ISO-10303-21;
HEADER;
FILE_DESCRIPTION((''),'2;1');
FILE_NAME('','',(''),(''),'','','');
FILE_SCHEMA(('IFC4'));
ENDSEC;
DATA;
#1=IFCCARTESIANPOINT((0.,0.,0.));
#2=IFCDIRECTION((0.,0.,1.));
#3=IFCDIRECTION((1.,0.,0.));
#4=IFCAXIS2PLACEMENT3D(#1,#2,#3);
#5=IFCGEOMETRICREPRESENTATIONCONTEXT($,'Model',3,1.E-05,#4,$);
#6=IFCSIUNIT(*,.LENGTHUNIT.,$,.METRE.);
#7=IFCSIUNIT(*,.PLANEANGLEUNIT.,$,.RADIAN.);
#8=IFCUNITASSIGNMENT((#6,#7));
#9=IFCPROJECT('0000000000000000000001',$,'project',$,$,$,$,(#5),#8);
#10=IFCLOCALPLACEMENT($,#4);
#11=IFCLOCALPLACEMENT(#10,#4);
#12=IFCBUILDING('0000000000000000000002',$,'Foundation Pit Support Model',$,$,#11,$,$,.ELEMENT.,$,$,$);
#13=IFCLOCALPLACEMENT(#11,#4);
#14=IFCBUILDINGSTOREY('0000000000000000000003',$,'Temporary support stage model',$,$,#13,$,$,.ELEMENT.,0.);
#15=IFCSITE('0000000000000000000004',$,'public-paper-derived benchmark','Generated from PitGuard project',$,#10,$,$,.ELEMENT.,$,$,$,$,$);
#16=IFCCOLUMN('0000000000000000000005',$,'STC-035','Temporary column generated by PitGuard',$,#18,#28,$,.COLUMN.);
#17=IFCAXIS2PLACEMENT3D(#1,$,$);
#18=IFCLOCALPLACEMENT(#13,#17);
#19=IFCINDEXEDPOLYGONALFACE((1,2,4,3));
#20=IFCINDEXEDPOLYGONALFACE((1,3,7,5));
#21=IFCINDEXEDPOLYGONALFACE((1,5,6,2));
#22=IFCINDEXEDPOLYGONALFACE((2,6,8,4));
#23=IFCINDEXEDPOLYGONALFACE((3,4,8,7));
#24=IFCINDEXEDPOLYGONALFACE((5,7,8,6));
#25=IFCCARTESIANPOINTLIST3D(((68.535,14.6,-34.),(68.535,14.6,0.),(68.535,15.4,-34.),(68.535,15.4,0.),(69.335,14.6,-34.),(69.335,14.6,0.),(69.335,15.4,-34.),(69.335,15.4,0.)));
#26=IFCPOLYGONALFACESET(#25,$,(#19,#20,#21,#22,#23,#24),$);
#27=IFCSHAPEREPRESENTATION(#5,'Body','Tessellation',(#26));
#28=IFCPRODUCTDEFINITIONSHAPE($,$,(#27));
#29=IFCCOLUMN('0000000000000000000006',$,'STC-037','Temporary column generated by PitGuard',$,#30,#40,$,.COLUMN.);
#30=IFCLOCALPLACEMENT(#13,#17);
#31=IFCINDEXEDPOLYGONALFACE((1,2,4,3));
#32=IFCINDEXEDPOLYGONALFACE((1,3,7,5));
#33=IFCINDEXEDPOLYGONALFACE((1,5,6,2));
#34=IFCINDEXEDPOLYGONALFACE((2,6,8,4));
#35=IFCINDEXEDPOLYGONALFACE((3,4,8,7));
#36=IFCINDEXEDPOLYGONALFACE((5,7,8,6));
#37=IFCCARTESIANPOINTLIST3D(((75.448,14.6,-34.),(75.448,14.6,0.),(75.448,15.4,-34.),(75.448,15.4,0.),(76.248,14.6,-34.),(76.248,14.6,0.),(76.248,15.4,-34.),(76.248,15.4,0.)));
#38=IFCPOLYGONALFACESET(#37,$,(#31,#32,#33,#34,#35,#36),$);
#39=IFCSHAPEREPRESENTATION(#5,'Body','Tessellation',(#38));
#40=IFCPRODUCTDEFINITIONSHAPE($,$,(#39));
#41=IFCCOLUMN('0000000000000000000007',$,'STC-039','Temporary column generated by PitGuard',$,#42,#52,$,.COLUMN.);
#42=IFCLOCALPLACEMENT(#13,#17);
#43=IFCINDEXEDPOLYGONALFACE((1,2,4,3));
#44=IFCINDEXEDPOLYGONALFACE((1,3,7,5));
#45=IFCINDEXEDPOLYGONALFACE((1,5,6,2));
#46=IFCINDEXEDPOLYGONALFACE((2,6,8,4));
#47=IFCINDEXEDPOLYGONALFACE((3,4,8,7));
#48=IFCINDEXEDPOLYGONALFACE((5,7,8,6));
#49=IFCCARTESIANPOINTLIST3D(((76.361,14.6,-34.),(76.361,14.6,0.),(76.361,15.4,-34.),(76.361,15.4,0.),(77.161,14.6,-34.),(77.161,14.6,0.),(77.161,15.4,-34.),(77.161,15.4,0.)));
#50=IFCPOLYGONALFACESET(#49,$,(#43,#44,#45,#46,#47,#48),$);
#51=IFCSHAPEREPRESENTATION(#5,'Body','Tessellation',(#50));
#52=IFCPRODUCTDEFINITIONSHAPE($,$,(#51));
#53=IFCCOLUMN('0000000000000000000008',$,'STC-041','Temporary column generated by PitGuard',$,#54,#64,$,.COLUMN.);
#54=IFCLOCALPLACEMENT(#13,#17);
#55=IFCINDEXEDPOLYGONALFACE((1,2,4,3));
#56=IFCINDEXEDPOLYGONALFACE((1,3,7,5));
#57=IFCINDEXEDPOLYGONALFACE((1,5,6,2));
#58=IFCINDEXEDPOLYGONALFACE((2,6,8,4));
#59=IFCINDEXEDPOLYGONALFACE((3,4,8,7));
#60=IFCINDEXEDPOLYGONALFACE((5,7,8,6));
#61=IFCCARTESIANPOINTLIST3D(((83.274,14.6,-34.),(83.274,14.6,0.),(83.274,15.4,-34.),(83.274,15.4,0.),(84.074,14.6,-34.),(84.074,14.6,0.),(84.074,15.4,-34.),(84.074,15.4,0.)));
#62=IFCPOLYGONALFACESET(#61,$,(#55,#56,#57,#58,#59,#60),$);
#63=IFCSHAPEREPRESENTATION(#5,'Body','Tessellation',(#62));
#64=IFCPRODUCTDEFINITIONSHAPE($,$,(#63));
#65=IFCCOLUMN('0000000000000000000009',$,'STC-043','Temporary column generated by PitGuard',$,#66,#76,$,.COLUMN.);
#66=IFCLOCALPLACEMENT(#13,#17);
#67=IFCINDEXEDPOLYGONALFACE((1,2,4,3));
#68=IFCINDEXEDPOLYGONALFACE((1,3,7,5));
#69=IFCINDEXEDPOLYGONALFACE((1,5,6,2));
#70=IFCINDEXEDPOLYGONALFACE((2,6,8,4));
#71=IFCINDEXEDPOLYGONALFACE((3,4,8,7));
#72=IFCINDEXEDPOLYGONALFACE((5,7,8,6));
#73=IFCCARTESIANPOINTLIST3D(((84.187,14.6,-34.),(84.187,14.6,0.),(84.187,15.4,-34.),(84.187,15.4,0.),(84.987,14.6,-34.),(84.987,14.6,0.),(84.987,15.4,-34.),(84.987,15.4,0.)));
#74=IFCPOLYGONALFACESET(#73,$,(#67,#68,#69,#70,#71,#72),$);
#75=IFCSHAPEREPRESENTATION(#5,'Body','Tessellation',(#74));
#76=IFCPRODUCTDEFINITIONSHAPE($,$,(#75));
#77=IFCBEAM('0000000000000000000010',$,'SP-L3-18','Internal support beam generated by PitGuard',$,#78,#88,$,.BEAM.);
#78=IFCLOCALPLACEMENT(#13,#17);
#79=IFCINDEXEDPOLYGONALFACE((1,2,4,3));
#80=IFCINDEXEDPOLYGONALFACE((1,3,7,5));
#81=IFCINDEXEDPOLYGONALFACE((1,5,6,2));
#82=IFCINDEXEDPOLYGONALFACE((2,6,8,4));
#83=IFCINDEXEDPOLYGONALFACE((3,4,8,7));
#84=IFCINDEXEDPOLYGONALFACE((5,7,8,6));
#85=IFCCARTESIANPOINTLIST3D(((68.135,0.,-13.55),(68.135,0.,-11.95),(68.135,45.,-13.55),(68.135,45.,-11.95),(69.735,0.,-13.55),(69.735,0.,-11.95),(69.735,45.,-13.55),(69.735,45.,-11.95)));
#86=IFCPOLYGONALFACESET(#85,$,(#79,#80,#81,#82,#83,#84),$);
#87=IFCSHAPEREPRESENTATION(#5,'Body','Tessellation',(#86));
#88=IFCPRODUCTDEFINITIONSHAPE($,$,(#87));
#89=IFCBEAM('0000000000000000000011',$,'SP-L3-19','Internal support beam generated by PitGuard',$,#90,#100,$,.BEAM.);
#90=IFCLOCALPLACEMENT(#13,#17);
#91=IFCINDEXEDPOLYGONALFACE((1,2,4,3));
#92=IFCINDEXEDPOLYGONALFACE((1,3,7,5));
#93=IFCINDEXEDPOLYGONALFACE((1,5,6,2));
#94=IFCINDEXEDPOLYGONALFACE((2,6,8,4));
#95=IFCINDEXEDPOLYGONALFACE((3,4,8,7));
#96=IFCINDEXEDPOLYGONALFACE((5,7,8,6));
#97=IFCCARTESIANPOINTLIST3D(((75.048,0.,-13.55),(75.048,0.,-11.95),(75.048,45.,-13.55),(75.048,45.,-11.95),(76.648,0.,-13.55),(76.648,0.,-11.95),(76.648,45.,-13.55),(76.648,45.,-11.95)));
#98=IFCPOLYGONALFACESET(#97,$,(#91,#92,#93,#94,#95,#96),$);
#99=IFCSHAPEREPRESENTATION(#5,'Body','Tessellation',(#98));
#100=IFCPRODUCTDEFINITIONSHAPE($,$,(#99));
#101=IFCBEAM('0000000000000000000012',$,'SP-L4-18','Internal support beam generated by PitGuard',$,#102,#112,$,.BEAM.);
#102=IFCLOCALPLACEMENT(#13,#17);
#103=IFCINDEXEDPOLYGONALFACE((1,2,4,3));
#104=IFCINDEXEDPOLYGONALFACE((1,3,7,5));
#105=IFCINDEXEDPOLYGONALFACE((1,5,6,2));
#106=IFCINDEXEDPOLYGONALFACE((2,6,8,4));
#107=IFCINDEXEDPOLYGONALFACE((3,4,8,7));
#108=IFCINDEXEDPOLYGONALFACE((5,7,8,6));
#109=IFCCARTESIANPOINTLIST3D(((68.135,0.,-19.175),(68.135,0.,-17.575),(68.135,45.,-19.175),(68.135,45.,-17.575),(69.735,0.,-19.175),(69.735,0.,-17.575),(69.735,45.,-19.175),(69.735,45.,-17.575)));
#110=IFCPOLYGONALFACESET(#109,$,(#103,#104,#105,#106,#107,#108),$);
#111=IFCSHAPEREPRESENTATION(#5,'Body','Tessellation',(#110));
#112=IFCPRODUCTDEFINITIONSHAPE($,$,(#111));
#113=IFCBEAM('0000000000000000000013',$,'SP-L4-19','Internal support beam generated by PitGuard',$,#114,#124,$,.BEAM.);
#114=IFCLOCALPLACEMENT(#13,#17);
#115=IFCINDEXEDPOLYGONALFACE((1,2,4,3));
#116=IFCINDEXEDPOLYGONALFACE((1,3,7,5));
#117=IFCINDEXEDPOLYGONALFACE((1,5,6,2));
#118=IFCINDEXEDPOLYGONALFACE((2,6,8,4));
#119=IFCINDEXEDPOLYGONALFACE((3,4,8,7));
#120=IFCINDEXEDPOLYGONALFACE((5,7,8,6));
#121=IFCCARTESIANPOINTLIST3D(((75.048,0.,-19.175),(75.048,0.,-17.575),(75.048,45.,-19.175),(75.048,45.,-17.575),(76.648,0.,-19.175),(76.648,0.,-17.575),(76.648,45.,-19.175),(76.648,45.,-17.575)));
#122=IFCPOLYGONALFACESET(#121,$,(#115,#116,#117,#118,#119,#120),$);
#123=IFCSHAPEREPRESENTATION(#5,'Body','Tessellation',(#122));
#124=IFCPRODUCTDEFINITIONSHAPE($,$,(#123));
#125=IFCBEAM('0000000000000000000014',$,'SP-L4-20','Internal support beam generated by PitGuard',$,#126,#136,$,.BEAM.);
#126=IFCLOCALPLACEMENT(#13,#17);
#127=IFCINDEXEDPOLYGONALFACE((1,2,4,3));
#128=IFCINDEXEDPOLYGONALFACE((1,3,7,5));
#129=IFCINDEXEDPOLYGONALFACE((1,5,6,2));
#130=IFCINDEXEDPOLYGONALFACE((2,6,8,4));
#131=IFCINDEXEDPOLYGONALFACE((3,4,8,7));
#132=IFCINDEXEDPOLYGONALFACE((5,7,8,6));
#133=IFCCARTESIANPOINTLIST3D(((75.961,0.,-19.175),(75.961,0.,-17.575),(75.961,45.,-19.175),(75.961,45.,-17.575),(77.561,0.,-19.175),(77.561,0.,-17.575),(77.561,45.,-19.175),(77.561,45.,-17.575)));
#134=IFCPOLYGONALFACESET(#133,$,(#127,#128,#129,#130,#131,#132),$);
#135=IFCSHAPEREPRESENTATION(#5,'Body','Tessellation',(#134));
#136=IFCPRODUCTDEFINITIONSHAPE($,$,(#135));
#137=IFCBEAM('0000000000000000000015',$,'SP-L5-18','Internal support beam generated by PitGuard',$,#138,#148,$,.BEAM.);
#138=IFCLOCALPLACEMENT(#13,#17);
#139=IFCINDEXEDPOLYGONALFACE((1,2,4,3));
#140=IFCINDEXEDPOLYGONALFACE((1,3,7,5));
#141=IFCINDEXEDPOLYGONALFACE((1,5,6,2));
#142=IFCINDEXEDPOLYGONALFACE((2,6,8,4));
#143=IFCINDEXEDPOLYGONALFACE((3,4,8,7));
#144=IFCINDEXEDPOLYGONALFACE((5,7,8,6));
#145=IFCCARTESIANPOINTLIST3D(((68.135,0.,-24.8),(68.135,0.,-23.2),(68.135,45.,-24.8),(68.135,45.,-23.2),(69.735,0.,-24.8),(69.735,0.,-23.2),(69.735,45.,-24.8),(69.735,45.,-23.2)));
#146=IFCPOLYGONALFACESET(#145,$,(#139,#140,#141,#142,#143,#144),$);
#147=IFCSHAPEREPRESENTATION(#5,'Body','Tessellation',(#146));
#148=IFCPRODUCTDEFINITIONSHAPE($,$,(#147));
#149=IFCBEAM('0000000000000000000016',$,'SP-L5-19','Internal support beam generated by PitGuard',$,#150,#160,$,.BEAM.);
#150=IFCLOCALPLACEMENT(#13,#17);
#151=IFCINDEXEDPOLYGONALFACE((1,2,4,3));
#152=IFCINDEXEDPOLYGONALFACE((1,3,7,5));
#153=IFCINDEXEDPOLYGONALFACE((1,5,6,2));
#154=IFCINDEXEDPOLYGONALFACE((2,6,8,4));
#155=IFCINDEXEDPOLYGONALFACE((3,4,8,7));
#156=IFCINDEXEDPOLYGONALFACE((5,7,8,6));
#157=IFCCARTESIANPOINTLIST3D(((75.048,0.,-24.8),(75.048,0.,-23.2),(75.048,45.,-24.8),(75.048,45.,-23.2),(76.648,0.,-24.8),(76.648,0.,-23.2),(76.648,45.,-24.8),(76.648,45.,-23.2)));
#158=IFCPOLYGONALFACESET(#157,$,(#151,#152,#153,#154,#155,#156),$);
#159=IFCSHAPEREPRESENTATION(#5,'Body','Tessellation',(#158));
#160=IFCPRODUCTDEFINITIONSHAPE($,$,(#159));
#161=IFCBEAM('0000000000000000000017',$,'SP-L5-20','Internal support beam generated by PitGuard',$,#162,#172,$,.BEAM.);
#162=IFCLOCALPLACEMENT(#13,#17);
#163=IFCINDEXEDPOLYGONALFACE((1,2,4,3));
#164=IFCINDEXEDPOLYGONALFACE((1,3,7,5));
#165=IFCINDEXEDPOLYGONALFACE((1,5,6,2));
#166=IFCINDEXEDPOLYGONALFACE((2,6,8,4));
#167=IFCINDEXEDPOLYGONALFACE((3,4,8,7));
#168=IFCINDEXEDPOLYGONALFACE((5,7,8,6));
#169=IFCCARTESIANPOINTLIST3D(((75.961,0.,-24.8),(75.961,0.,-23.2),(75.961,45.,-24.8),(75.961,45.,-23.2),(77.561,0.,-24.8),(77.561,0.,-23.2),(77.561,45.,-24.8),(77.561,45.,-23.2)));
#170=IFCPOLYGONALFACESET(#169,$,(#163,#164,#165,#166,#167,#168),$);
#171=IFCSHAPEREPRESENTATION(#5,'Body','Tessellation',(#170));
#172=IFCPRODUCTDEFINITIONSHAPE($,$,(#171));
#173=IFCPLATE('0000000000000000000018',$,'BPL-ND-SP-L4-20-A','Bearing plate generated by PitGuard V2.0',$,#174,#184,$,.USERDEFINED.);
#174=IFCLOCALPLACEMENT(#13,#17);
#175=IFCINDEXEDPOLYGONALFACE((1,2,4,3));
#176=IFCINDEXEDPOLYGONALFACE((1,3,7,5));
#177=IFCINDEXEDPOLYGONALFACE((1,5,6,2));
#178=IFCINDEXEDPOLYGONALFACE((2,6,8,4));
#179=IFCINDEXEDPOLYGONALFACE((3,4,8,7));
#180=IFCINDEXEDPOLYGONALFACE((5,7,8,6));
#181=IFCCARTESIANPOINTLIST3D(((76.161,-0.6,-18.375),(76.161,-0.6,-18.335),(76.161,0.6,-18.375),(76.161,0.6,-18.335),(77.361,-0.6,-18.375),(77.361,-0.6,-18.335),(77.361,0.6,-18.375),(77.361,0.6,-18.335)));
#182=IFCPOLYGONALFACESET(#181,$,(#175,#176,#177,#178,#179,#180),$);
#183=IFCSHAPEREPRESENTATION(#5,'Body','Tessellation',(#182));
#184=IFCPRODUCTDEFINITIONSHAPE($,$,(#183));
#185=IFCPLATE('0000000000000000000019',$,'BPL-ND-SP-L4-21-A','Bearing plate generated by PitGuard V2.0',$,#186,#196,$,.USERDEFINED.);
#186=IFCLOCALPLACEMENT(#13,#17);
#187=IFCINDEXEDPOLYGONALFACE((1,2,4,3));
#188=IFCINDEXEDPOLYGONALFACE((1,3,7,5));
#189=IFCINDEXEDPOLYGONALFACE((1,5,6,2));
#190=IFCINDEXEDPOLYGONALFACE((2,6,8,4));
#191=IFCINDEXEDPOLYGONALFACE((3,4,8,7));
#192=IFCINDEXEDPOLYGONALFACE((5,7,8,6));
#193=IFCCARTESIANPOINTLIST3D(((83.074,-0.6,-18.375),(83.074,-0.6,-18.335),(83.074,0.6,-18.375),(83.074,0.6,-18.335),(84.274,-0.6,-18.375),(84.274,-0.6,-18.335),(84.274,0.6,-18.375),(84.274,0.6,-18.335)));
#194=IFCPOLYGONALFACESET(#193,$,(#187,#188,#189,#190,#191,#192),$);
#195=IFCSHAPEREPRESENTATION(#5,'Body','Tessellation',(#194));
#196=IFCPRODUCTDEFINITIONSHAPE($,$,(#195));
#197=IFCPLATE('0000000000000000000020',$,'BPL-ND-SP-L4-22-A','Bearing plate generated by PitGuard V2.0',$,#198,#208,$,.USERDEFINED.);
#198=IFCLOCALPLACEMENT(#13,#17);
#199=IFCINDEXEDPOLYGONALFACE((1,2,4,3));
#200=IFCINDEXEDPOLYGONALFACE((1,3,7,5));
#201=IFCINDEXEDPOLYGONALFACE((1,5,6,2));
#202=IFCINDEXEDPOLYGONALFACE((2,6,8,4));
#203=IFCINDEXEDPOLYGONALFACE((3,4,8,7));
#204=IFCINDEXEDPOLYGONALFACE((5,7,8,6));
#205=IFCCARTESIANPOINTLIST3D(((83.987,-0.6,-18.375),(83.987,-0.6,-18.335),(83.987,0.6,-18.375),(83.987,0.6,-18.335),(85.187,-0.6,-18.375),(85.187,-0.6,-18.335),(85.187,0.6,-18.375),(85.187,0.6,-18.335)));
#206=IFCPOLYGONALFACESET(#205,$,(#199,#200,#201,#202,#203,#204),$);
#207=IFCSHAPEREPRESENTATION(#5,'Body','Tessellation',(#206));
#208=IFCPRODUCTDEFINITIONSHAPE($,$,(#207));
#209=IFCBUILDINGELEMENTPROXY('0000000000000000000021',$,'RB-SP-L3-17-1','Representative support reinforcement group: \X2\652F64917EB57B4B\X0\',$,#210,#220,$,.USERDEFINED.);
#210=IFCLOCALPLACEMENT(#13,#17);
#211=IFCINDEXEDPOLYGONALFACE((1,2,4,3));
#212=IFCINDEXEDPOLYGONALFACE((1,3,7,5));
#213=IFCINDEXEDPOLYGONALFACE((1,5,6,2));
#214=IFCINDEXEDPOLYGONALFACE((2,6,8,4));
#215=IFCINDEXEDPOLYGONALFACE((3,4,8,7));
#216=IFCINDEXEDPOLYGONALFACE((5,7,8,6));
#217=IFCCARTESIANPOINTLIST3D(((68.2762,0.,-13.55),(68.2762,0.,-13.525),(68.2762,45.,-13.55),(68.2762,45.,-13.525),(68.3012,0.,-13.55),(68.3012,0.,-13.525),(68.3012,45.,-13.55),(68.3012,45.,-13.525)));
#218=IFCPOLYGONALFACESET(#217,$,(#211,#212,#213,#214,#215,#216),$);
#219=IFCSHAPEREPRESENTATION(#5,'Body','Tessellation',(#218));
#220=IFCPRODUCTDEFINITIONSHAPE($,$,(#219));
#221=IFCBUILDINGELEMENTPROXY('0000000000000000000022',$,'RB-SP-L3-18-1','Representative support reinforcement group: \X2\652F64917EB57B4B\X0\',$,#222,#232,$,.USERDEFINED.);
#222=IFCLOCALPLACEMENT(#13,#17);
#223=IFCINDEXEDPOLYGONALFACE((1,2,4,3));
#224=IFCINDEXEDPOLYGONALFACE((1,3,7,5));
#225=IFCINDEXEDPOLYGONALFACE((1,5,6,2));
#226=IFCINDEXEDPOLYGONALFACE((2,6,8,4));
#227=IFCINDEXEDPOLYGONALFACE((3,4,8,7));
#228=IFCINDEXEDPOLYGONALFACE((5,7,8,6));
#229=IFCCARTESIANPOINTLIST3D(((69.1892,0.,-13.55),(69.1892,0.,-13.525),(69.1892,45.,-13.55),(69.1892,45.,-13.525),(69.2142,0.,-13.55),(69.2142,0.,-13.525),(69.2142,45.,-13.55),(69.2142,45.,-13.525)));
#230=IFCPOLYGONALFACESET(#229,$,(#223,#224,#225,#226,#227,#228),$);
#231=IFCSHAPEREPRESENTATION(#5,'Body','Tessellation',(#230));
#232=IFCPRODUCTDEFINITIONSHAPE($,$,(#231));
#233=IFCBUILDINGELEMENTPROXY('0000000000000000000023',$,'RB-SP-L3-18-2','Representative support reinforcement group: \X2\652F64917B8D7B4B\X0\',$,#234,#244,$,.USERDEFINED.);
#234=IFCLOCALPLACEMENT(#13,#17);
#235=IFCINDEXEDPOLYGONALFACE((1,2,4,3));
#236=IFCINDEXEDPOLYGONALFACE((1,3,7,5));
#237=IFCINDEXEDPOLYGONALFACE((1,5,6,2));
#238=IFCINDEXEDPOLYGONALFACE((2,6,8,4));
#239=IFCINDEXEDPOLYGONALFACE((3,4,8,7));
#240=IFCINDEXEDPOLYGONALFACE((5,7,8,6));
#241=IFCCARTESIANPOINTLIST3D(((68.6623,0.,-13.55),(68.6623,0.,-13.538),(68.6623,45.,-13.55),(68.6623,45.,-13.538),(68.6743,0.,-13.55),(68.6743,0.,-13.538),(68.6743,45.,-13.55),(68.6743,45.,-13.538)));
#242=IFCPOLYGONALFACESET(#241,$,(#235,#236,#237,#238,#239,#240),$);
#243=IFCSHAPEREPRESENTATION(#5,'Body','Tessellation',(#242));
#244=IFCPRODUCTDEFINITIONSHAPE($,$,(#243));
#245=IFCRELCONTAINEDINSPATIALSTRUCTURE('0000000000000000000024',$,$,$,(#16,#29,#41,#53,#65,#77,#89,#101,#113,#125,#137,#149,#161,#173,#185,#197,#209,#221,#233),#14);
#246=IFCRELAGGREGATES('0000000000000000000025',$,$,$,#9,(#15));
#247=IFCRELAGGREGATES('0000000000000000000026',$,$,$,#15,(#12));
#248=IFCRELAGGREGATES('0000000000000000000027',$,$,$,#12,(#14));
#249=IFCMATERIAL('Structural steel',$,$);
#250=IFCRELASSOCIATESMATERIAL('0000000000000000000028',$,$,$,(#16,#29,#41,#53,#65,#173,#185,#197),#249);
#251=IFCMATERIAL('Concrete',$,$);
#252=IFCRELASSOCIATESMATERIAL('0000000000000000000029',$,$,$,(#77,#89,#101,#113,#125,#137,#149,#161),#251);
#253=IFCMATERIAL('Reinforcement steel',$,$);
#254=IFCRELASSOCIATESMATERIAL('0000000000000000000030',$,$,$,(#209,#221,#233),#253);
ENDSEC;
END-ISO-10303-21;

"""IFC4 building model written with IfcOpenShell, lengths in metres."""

from ifc_helpers import new_model, si_unit, frame, origin_with_axes, origin_2d, place, context, project, spatial, rectangle, extrude, material, element, save


model = new_model("IFC4")

# Units and contexts
model_context = context("Model", 3, precision=1e-05, world=origin_with_axes())
ifc_project = project(units=[si_unit("LENGTHUNIT", "METRE"), si_unit("PLANEANGLEUNIT", "RADIAN")], contexts=[model_context])

# Site, building, storey
site_placement = place(None, origin_with_axes())
site = spatial("IfcSite", under=ifc_project, at=site_placement, Name="public-paper-derived benchmark", Description="Generated from PitGuard project", CompositionType="ELEMENT")
building_placement = place(site_placement, origin_with_axes())
building = spatial("IfcBuilding", under=site, at=building_placement, Name="Foundation Pit Support Model", CompositionType="ELEMENT")
storey_placement = place(building_placement, origin_with_axes())
storey = spatial("IfcBuildingStorey", under=building, at=storey_placement, Name="Temporary support stage model", CompositionType="ELEMENT", Elevation=0.0)

# Columns
ifc_material_1 = material(Name="Structural steel")
for number, where, z_axis, x_axis, name in (
    (1, (68.935, 15.0, -34.0), (0.0, 0.0, 1.0), (1.0, 0.0, 0.0), "STC-035"),
    (2, (75.848, 15.0, -34.0), (0.0, 0.0, 1.0), (1.0, 0.0, 0.0), "STC-037"),
    (3, (76.761, 15.0, -34.0), (0.0, 0.0, 1.0), (1.0, 0.0, 0.0), "STC-039"),
    (4, (83.674, 15.0, -34.0), (0.0, 0.0, 1.0), (1.0, 0.0, 0.0), "STC-041"),
    (5, (84.587, 15.0, -34.0), (0.0, 0.0, 1.0), (1.0, 0.0, 0.0), "STC-043"),
):
    element("IfcColumn", number, at=place(storey_placement, frame(where, z_axis=z_axis, x_axis=x_axis)), inside=storey, material=ifc_material_1, Name=name, Description="Temporary column generated by PitGuard", PredefinedType="COLUMN", context=model_context, shape_type="SweptSolid", body=[
        extrude(rectangle(XDim=0.8, YDim=0.8, at=origin_2d()), origin_with_axes(), (0.0, 0.0, 1.0), 34.0),
    ])

# Beams
ifc_material_2 = material(Name="Concrete")
for number, where, z_axis, x_axis, name in (
    (6, (68.935, 22.5, -13.55), (0.0, 0.0, 1.0), (0.0, 1.0, 0.0), "SP-L3-18"),
    (7, (75.848, 22.5, -13.55), (0.0, 0.0, 1.0), (0.0, 1.0, 0.0), "SP-L3-19"),
    (8, (68.935, 22.5, -19.175), (0.0, 0.0, 1.0), (0.0, 1.0, 0.0), "SP-L4-18"),
    (9, (75.848, 22.5, -19.175), (0.0, 0.0, 1.0), (0.0, 1.0, 0.0), "SP-L4-19"),
    (10, (76.761, 22.5, -19.175), (0.0, 0.0, 1.0), (0.0, 1.0, 0.0), "SP-L4-20"),
    (11, (68.935, 22.5, -24.8), (0.0, 0.0, 1.0), (0.0, 1.0, 0.0), "SP-L5-18"),
    (12, (75.848, 22.5, -24.8), (0.0, 0.0, 1.0), (0.0, 1.0, 0.0), "SP-L5-19"),
    (13, (76.761, 22.5, -24.8), (0.0, 0.0, 1.0), (0.0, 1.0, 0.0), "SP-L5-20"),
):
    element("IfcBeam", number, at=place(storey_placement, frame(where, z_axis=z_axis, x_axis=x_axis)), inside=storey, material=ifc_material_2, Name=name, Description="Internal support beam generated by PitGuard", PredefinedType="BEAM", context=model_context, shape_type="SweptSolid", body=[
        extrude(rectangle(XDim=45.0, YDim=1.6, at=origin_2d()), origin_with_axes(), (0.0, 0.0, 1.0), 1.6),
    ])

# Plates
for number, where, z_axis, x_axis, name in (
    (14, (76.761, 0.0, -18.375), (0.0, 0.0, 1.0), (1.0, 0.0, 0.0), "BPL-ND-SP-L4-20-A"),
    (15, (83.674, 0.0, -18.375), (0.0, 0.0, 1.0), (1.0, 0.0, 0.0), "BPL-ND-SP-L4-21-A"),
    (16, (84.587, 0.0, -18.375), (0.0, 0.0, 1.0), (1.0, 0.0, 0.0), "BPL-ND-SP-L4-22-A"),
):
    element("IfcPlate", number, at=place(storey_placement, frame(where, z_axis=z_axis, x_axis=x_axis)), inside=storey, material=ifc_material_1, Name=name, Description="Bearing plate generated by PitGuard V2.0", PredefinedType="USERDEFINED", context=model_context, shape_type="SweptSolid", body=[
        extrude(rectangle(XDim=1.2, YDim=1.2, at=origin_2d()), origin_with_axes(), (0.0, 0.0, 1.0), 0.04),
    ])

# Building element proxies
ifc_material_3 = material(Name="Reinforcement steel")
for number, where, z_axis, x_axis, name in (
    (17, (68.2887, 22.5, -13.55), (0.0, 0.0, 1.0), (0.0, 1.0, 0.0), "RB-SP-L3-17-1"),
    (18, (69.2017, 22.5, -13.55), (0.0, 0.0, 1.0), (0.0, 1.0, 0.0), "RB-SP-L3-18-1"),
):
    element("IfcBuildingElementProxy", number, at=place(storey_placement, frame(where, z_axis=z_axis, x_axis=x_axis)), inside=storey, material=ifc_material_3, Name=name, Description="Representative support reinforcement group: 支撑纵筋", PredefinedType="USERDEFINED", context=model_context, shape_type="SweptSolid", body=[
        extrude(rectangle(XDim=45.0, YDim=0.025, at=origin_2d()), origin_with_axes(), (0.0, 0.0, 1.0), 0.025),
    ])
proxy_1_placement = place(storey_placement, frame((68.6683, 22.5, -13.55), z_axis=(0.0, 0.0, 1.0), x_axis=(0.0, 1.0, 0.0)))
element("IfcBuildingElementProxy", 19, at=proxy_1_placement, inside=storey, material=ifc_material_3, Name="RB-SP-L3-18-2", Description="Representative support reinforcement group: 支撑箍筋", PredefinedType="USERDEFINED", context=model_context, shape_type="SweptSolid", body=[
    extrude(rectangle(XDim=45.0, YDim=0.012, at=origin_2d()), origin_with_axes(), (0.0, 0.0, 1.0), 0.012),
])

save(model, "model.ifc")
